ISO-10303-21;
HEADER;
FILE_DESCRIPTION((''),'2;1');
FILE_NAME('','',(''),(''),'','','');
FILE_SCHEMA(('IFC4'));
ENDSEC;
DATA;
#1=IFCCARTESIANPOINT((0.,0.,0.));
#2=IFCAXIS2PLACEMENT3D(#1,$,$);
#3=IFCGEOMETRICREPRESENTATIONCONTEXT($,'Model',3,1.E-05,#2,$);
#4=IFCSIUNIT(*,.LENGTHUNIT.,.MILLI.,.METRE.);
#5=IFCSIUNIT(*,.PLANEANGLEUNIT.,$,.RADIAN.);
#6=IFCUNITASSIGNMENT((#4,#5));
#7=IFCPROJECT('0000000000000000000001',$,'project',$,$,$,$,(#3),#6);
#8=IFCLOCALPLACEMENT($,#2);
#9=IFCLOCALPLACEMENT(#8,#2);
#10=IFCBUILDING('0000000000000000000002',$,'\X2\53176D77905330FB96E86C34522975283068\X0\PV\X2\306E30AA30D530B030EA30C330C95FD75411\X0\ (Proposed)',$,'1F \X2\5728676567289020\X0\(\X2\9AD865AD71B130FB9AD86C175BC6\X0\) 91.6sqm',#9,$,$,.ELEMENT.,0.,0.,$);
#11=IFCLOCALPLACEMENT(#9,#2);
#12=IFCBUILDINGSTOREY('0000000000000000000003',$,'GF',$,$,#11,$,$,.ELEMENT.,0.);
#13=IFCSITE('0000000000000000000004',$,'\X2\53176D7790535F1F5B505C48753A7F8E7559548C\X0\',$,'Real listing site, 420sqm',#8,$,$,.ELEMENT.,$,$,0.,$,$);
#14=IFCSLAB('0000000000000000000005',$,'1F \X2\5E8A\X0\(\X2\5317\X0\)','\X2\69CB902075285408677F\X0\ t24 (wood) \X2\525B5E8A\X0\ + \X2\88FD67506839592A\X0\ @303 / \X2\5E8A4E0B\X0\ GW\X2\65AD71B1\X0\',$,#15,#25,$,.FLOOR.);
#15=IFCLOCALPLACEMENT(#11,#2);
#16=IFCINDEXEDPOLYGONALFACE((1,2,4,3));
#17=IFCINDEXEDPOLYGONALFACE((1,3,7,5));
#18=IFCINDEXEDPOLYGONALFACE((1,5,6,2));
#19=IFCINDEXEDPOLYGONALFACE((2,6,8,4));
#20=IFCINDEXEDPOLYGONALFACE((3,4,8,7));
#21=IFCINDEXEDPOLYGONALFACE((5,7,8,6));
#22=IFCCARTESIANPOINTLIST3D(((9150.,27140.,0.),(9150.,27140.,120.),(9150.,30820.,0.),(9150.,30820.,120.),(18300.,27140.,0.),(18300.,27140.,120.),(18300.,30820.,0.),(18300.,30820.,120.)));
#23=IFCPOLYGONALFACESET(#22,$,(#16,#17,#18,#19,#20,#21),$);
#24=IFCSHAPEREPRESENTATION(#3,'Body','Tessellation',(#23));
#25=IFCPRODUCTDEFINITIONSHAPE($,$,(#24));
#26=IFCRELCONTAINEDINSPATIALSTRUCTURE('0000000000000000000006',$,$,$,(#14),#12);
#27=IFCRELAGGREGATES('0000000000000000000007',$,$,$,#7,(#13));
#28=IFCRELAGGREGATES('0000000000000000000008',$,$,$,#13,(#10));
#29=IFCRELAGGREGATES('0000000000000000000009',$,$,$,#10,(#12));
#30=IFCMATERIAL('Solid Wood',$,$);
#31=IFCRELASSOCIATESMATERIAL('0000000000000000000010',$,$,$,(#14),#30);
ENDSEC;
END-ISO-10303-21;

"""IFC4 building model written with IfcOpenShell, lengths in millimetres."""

from ifc_helpers import new_model, si_unit, frame, frame_2d, origin, place, context, project, spatial, rectangle, extrude, material, element, save


model = new_model("IFC4")

# Units and contexts
model_context = context("Model", 3, precision=1e-05, world=origin())
ifc_project = project(units=[si_unit("LENGTHUNIT", "METRE", prefix="MILLI"), si_unit("PLANEANGLEUNIT", "RADIAN")], contexts=[model_context])

# Site, building, storey
site_placement = place(None, origin())
site = spatial("IfcSite", under=ifc_project, at=site_placement, Name="北海道弟子屈町美留和", ObjectType="Real listing site, 420sqm", CompositionType="ELEMENT", RefElevation=0.0)
building_placement = place(site_placement, origin())
building = spatial("IfcBuilding", under=site, at=building_placement, Name="北海道・雨水利用とPVのオフグリッド志向 (Proposed)", ObjectType="1F 在来木造(高断熱・高気密) 91.6sqm", CompositionType="ELEMENT", ElevationOfRefHeight=0.0, ElevationOfTerrain=0.0)
storey_placement = place(building_placement, origin())
storey = spatial("IfcBuildingStorey", under=building, at=storey_placement, Name="GF", CompositionType="ELEMENT", Elevation=0.0)

# Shared definitions
ifc_material_1 = material(Name="Solid Wood")

# Slab
slab_placement = place(storey_placement, frame((4575.0, 13570.0, 0.0)))
element("IfcSlab", 1, at=slab_placement, inside=storey, material=ifc_material_1, Name="1F 床(北)", Description="構造用合板 t24 (wood) 剛床 + 製材根太 @303 / 床下 GW断熱", PredefinedType="FLOOR", context=model_context, shape_type="SweptSolid", body=[
    extrude(rectangle(XDim=9150.0, YDim=3680.0, at=frame_2d((4575.0, 1840.0))), frame((4575.0, 13570.0, 0.0)), (0.0, 0.0, 1.0), 120.0),
])

save(model, "model.ifc")
